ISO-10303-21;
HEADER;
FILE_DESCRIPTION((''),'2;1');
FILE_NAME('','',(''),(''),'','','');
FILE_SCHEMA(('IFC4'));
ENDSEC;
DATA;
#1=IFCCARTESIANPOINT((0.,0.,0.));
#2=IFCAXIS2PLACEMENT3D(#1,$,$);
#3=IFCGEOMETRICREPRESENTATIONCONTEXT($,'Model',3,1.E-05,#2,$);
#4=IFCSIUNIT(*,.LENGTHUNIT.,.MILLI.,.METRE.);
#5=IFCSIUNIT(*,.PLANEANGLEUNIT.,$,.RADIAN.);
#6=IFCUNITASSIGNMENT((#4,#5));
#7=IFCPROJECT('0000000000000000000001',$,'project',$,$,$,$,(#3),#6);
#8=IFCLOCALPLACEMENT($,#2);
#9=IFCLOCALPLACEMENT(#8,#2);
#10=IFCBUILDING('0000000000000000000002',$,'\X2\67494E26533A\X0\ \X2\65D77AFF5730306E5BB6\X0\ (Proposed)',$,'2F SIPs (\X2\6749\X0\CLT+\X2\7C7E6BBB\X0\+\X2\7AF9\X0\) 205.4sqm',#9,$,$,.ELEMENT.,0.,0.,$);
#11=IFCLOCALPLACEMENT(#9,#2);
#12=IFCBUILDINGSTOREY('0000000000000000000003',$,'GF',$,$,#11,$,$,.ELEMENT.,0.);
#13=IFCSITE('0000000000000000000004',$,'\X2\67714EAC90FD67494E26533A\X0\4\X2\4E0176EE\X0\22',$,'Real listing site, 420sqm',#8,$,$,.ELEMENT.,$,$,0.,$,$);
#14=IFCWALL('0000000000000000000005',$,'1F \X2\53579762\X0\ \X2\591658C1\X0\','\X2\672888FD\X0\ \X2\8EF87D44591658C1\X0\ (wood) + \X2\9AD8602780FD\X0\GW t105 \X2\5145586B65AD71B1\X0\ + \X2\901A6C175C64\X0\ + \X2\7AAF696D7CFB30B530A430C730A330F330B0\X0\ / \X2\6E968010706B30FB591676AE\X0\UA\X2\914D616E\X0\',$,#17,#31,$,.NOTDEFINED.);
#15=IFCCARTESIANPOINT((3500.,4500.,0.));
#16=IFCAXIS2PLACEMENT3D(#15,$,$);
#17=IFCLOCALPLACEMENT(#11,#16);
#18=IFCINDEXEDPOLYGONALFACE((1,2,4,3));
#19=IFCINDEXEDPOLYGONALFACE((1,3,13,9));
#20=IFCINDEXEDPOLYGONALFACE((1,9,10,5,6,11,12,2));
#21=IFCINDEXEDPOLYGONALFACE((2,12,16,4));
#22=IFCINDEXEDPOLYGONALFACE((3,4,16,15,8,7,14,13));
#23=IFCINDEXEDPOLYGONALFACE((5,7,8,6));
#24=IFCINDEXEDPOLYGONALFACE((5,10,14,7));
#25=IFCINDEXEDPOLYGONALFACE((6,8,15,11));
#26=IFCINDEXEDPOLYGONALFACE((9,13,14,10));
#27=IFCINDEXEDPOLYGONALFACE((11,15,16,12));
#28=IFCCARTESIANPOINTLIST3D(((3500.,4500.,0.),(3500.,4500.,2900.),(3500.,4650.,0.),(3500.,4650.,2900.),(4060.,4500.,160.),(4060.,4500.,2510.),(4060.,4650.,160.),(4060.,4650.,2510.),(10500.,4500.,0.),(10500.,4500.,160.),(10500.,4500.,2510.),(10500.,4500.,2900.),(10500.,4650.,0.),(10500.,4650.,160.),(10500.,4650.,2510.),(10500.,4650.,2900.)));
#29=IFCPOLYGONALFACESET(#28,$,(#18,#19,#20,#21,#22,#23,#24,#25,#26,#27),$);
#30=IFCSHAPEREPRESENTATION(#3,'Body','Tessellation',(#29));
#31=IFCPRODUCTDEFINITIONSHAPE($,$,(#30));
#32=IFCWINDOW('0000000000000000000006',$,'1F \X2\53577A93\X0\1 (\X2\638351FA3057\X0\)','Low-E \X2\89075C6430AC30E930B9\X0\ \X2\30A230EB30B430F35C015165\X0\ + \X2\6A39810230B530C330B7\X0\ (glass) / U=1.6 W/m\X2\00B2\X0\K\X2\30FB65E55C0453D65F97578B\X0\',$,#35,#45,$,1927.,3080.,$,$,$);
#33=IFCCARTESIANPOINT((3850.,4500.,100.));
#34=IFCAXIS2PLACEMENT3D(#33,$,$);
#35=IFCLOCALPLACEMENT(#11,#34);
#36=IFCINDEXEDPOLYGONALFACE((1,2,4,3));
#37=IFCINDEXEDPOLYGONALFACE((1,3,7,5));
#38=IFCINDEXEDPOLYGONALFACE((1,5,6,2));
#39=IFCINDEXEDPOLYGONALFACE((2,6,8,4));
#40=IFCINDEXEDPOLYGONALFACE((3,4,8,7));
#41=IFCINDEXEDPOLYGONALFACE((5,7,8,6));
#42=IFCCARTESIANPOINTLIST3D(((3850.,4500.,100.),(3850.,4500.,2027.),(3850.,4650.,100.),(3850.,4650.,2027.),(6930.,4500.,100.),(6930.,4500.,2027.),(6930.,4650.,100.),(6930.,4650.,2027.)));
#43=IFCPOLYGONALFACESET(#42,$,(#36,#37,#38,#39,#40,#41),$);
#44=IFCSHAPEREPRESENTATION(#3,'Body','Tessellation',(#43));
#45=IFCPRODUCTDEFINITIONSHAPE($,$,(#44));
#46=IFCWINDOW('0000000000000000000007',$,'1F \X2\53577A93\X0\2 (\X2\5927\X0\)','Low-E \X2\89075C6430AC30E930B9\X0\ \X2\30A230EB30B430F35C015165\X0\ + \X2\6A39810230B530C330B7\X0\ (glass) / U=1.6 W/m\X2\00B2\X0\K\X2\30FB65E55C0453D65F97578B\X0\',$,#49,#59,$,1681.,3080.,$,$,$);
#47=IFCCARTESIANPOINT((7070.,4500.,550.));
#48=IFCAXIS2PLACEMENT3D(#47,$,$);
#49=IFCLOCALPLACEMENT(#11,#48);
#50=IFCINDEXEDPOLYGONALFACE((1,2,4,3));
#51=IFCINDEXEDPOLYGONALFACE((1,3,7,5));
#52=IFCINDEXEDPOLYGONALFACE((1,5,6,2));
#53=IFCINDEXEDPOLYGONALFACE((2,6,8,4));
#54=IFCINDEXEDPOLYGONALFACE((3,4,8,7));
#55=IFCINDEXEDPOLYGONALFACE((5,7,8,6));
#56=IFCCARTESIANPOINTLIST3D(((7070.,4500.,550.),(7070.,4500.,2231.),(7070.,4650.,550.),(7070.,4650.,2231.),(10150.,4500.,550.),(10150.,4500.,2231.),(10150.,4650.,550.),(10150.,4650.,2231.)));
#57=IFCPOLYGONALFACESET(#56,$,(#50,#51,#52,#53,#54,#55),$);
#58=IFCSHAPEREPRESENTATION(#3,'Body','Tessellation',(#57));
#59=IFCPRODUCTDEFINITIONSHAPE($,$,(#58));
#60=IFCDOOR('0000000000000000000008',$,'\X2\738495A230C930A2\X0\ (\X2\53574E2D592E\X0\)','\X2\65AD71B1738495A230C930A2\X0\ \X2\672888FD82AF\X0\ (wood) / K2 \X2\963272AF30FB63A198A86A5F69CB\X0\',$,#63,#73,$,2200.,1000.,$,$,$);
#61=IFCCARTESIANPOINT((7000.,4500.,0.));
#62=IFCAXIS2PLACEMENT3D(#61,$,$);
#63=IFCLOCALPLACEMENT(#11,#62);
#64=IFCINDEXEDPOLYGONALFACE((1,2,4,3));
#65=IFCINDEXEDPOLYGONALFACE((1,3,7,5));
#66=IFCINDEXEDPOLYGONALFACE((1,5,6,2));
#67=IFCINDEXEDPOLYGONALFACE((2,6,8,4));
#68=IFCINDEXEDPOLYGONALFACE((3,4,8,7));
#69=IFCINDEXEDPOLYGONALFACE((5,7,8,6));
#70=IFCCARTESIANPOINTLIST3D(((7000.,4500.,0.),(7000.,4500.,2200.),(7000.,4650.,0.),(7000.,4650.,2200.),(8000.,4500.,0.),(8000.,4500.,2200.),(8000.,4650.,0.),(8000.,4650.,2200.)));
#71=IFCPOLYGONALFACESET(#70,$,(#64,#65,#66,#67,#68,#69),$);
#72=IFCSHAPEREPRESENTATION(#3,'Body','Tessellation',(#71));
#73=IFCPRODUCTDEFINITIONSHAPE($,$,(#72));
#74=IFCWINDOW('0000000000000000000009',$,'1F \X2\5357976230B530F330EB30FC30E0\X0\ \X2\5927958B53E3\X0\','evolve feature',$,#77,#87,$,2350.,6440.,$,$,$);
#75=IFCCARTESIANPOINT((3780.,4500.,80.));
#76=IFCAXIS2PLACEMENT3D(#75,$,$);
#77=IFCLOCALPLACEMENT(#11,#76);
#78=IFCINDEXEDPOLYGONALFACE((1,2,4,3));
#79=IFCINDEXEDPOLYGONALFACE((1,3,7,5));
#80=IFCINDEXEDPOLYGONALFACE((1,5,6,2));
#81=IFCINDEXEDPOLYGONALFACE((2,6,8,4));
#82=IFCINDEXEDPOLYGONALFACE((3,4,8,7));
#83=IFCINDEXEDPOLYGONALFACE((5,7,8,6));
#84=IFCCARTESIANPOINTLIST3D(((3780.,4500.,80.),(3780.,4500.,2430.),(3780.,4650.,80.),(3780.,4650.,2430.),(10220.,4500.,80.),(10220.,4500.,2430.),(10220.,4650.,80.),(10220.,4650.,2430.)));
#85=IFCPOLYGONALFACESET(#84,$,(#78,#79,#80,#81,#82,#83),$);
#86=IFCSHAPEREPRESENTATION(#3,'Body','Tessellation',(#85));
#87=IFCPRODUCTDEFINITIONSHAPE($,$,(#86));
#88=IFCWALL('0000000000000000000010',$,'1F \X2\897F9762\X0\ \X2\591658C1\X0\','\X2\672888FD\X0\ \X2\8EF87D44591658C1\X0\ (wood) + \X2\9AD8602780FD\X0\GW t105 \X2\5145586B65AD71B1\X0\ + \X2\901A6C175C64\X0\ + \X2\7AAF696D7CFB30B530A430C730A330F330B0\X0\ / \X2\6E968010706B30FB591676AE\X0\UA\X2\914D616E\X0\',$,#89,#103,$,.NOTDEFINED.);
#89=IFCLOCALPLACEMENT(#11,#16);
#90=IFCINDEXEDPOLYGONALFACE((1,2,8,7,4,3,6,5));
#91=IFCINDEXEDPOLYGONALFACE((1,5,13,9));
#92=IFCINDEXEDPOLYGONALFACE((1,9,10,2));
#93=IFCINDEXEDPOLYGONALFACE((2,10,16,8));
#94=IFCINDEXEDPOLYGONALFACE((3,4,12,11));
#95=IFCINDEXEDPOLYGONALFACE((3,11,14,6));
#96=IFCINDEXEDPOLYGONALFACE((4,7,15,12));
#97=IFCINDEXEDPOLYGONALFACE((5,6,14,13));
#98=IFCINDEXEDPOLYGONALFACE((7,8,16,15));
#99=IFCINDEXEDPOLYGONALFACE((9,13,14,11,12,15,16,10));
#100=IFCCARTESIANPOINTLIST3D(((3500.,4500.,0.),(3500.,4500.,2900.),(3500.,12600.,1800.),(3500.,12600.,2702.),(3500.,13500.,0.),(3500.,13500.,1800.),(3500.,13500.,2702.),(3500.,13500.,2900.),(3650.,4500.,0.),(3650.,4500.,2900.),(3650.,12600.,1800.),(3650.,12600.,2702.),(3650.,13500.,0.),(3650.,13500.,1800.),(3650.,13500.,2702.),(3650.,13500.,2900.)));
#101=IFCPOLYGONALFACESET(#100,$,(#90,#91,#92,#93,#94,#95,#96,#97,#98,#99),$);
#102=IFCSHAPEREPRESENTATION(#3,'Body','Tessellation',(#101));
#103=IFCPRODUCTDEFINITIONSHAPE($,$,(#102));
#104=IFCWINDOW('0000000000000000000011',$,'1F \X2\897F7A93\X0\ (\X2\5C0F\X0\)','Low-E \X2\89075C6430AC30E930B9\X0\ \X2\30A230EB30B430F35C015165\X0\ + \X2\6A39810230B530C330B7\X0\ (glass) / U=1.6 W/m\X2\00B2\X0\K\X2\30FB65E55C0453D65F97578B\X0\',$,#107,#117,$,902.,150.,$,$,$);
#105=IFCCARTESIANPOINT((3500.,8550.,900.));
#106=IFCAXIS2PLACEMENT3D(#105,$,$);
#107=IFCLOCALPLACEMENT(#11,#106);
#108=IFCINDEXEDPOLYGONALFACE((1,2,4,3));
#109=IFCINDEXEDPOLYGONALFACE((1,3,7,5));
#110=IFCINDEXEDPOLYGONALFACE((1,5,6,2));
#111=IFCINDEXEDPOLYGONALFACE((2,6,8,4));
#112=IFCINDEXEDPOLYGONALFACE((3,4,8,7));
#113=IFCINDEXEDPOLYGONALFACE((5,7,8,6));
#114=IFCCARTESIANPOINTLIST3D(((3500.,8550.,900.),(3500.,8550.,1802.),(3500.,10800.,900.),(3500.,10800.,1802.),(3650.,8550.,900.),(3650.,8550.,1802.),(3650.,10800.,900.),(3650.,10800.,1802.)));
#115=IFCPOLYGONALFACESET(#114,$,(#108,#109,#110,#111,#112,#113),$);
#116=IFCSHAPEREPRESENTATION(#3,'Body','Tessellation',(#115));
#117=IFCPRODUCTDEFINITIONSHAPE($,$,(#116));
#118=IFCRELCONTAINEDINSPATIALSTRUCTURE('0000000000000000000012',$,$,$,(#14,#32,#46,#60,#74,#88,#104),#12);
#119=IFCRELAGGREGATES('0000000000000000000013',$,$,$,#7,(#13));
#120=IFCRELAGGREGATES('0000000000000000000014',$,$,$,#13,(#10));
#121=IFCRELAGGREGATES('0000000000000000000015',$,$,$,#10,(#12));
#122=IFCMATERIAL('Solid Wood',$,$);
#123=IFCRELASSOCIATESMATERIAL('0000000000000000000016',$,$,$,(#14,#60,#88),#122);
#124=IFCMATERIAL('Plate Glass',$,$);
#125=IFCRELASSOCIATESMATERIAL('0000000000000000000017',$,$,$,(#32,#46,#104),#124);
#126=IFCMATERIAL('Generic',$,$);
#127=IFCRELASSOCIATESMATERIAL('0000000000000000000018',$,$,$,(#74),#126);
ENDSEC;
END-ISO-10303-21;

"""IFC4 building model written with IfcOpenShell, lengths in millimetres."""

from ifc_helpers import new_model, si_unit, frame, frame_2d, origin, place, context, project, spatial, rectangle, extrude, material, element, fill, save


model = new_model("IFC4")

# Units and contexts
model_context = context("Model", 3, precision=1e-05, world=origin())
ifc_project = project(units=[si_unit("LENGTHUNIT", "METRE", prefix="MILLI"), si_unit("PLANEANGLEUNIT", "RADIAN")], contexts=[model_context])

# Site, building, storey
site_placement = place(None, origin())
site = spatial("IfcSite", under=ifc_project, at=site_placement, Name="東京都杉並区4丁目22", ObjectType="Real listing site, 420sqm", CompositionType="ELEMENT", RefElevation=0.0)
building_placement = place(site_placement, origin())
building = spatial("IfcBuilding", under=site, at=building_placement, Name="杉並区 旗竿地の家 (Proposed)", ObjectType="2F SIPs (杉CLT+籾殻+竹) 205.4sqm", CompositionType="ELEMENT", ElevationOfRefHeight=0.0, ElevationOfTerrain=0.0)
storey_placement = place(building_placement, origin())
storey = spatial("IfcBuildingStorey", under=building, at=storey_placement, Name="GF", CompositionType="ELEMENT", Elevation=0.0)

# Shared definitions
ifc_material_1 = material(Name="Solid Wood")
ifc_material_2 = material(Name="Generic")

# Wall, openings, windows, door
wall_1_placement = place(storey_placement, frame((3500.0, 4500.0, 0.0)))
wall_1 = element("IfcWall", 1, at=wall_1_placement, inside=storey, material=ifc_material_1, Name="1F 南面 外壁", Description="木製 軸組外壁 (wood) + 高性能GW t105 充填断熱 + 通気層 + 窯業系サイディング / 準耐火・外皮UA配慮", PredefinedType="NOTDEFINED", context=model_context, shape_type="SweptSolid", body=[
    extrude(rectangle(XDim=7000.0, YDim=150.0, at=frame_2d((3500.0, 75.0))), frame((3500.0, 4500.0, 0.0)), (0.0, 0.0, 1.0), 2900.0),
])
opening_1_placement = place(storey_placement, frame((3850.0, 4500.0, 100.0)))
opening_1 = element("IfcOpeningElement", 2, at=opening_1_placement, cuts=wall_1, PredefinedType="NOTDEFINED", context=model_context, shape_type="SweptSolid", body=[
    extrude(rectangle(XDim=3080.0, YDim=150.0, at=frame_2d((1540.0, 75.0))), frame((3850.0, 4500.0, 100.0)), (0.0, 0.0, 1.0), 1927.0),
])
opening_2_placement = place(storey_placement, frame((7070.0, 4500.0, 550.0)))
opening_2 = element("IfcOpeningElement", 3, at=opening_2_placement, cuts=wall_1, PredefinedType="NOTDEFINED", context=model_context, shape_type="SweptSolid", body=[
    extrude(rectangle(XDim=3080.0, YDim=150.0, at=frame_2d((1540.0, 75.0))), frame((7070.0, 4500.0, 550.0)), (0.0, 0.0, 1.0), 1681.0),
])
opening_3_placement = place(storey_placement, frame((7000.0, 4500.0, 0.0)))
opening_3 = element("IfcOpeningElement", 4, at=opening_3_placement, cuts=wall_1, PredefinedType="NOTDEFINED", context=model_context, shape_type="SweptSolid", body=[
    extrude(rectangle(XDim=1000.0, YDim=150.0, at=frame_2d((500.0, 75.0))), frame((7000.0, 4500.0, 0.0)), (0.0, 0.0, 1.0), 2200.0),
])
opening_4_placement = place(storey_placement, frame((3780.0, 4500.0, 80.0)))
opening_4 = element("IfcOpeningElement", 5, at=opening_4_placement, cuts=wall_1, PredefinedType="NOTDEFINED", context=model_context, shape_type="SweptSolid", body=[
    extrude(rectangle(XDim=6440.0, YDim=150.0, at=frame_2d((3220.0, 75.0))), frame((3780.0, 4500.0, 80.0)), (0.0, 0.0, 1.0), 2350.0),
])
ifc_material_3 = material(Name="Plate Glass")
window_1_placement = place(storey_placement, frame((3850.0, 4500.0, 100.0)))
window_1 = element("IfcWindow", 6, at=window_1_placement, inside=storey, material=ifc_material_3, Name="1F 南窓1 (掃出し)", Description="Low-E 複層ガラス アルゴン封入 + 樹脂サッシ (glass) / U=1.6 W/m²K・日射取得型", OverallHeight=1927.0, OverallWidth=3080.0, context=model_context, shape_type="SweptSolid", body=[
    extrude(rectangle(XDim=3080.0, YDim=150.0, at=frame_2d((1540.0, 75.0))), frame((3850.0, 4500.0, 100.0)), (0.0, 0.0, 1.0), 1927.0),
])
fill(opening_1, window_1)
window_2_placement = place(storey_placement, frame((7070.0, 4500.0, 550.0)))
window_2 = element("IfcWindow", 7, at=window_2_placement, inside=storey, material=ifc_material_3, Name="1F 南窓2 (大)", Description="Low-E 複層ガラス アルゴン封入 + 樹脂サッシ (glass) / U=1.6 W/m²K・日射取得型", OverallHeight=1681.0, OverallWidth=3080.0, context=model_context, shape_type="SweptSolid", body=[
    extrude(rectangle(XDim=3080.0, YDim=150.0, at=frame_2d((1540.0, 75.0))), frame((7070.0, 4500.0, 550.0)), (0.0, 0.0, 1.0), 1681.0),
])
fill(opening_2, window_2)
door_placement = place(storey_placement, frame((7000.0, 4500.0, 0.0)))
door = element("IfcDoor", 8, at=door_placement, inside=storey, material=ifc_material_1, Name="玄関ドア (南中央)", Description="断熱玄関ドア 木製芯 (wood) / K2 防犯・採風機構", OverallHeight=2200.0, OverallWidth=1000.0, context=model_context, shape_type="SweptSolid", body=[
    extrude(rectangle(XDim=1000.0, YDim=150.0, at=frame_2d((500.0, 75.0))), frame((7000.0, 4500.0, 0.0)), (0.0, 0.0, 1.0), 2200.0),
])
fill(opening_3, door)
window_3_placement = place(storey_placement, frame((3780.0, 4500.0, 80.0)))
window_3 = element("IfcWindow", 9, at=window_3_placement, inside=storey, material=ifc_material_2, Name="1F 南面サンルーム 大開口", Description="evolve feature", OverallHeight=2350.0, OverallWidth=6440.0, context=model_context, shape_type="SweptSolid", body=[
    extrude(rectangle(XDim=6440.0, YDim=150.0, at=frame_2d((3220.0, 75.0))), frame((3780.0, 4500.0, 80.0)), (0.0, 0.0, 1.0), 2350.0),
])
fill(opening_4, window_3)

# Wall, opening, window
wall_2_placement = place(storey_placement, frame((3500.0, 4500.0, 0.0)))
wall_2 = element("IfcWall", 10, at=wall_2_placement, inside=storey, material=ifc_material_1, Name="1F 西面 外壁", Description="木製 軸組外壁 (wood) + 高性能GW t105 充填断熱 + 通気層 + 窯業系サイディング / 準耐火・外皮UA配慮", PredefinedType="NOTDEFINED", context=model_context, shape_type="SweptSolid", body=[
    extrude(rectangle(XDim=150.0, YDim=9000.0, at=frame_2d((75.0, 4500.0))), frame((3500.0, 4500.0, 0.0)), (0.0, 0.0, 1.0), 2900.0),
])
opening_5_placement = place(storey_placement, frame((3500.0, 8550.0, 900.0)))
opening_5 = element("IfcOpeningElement", 11, at=opening_5_placement, cuts=wall_2, PredefinedType="NOTDEFINED", context=model_context, shape_type="SweptSolid", body=[
    extrude(rectangle(XDim=150.0, YDim=2250.0, at=frame_2d((75.0, 1125.0))), frame((3500.0, 8550.0, 900.0)), (0.0, 0.0, 1.0), 902.0),
])
window_4_placement = place(storey_placement, frame((3500.0, 8550.0, 900.0)))
window_4 = element("IfcWindow", 12, at=window_4_placement, inside=storey, material=ifc_material_3, Name="1F 西窓 (小)", Description="Low-E 複層ガラス アルゴン封入 + 樹脂サッシ (glass) / U=1.6 W/m²K・日射取得型", OverallHeight=902.0, OverallWidth=150.0, context=model_context, shape_type="SweptSolid", body=[
    extrude(rectangle(XDim=150.0, YDim=2250.0, at=frame_2d((75.0, 1125.0))), frame((3500.0, 8550.0, 900.0)), (0.0, 0.0, 1.0), 902.0),
])
fill(opening_5, window_4)

save(model, "model.ifc")
